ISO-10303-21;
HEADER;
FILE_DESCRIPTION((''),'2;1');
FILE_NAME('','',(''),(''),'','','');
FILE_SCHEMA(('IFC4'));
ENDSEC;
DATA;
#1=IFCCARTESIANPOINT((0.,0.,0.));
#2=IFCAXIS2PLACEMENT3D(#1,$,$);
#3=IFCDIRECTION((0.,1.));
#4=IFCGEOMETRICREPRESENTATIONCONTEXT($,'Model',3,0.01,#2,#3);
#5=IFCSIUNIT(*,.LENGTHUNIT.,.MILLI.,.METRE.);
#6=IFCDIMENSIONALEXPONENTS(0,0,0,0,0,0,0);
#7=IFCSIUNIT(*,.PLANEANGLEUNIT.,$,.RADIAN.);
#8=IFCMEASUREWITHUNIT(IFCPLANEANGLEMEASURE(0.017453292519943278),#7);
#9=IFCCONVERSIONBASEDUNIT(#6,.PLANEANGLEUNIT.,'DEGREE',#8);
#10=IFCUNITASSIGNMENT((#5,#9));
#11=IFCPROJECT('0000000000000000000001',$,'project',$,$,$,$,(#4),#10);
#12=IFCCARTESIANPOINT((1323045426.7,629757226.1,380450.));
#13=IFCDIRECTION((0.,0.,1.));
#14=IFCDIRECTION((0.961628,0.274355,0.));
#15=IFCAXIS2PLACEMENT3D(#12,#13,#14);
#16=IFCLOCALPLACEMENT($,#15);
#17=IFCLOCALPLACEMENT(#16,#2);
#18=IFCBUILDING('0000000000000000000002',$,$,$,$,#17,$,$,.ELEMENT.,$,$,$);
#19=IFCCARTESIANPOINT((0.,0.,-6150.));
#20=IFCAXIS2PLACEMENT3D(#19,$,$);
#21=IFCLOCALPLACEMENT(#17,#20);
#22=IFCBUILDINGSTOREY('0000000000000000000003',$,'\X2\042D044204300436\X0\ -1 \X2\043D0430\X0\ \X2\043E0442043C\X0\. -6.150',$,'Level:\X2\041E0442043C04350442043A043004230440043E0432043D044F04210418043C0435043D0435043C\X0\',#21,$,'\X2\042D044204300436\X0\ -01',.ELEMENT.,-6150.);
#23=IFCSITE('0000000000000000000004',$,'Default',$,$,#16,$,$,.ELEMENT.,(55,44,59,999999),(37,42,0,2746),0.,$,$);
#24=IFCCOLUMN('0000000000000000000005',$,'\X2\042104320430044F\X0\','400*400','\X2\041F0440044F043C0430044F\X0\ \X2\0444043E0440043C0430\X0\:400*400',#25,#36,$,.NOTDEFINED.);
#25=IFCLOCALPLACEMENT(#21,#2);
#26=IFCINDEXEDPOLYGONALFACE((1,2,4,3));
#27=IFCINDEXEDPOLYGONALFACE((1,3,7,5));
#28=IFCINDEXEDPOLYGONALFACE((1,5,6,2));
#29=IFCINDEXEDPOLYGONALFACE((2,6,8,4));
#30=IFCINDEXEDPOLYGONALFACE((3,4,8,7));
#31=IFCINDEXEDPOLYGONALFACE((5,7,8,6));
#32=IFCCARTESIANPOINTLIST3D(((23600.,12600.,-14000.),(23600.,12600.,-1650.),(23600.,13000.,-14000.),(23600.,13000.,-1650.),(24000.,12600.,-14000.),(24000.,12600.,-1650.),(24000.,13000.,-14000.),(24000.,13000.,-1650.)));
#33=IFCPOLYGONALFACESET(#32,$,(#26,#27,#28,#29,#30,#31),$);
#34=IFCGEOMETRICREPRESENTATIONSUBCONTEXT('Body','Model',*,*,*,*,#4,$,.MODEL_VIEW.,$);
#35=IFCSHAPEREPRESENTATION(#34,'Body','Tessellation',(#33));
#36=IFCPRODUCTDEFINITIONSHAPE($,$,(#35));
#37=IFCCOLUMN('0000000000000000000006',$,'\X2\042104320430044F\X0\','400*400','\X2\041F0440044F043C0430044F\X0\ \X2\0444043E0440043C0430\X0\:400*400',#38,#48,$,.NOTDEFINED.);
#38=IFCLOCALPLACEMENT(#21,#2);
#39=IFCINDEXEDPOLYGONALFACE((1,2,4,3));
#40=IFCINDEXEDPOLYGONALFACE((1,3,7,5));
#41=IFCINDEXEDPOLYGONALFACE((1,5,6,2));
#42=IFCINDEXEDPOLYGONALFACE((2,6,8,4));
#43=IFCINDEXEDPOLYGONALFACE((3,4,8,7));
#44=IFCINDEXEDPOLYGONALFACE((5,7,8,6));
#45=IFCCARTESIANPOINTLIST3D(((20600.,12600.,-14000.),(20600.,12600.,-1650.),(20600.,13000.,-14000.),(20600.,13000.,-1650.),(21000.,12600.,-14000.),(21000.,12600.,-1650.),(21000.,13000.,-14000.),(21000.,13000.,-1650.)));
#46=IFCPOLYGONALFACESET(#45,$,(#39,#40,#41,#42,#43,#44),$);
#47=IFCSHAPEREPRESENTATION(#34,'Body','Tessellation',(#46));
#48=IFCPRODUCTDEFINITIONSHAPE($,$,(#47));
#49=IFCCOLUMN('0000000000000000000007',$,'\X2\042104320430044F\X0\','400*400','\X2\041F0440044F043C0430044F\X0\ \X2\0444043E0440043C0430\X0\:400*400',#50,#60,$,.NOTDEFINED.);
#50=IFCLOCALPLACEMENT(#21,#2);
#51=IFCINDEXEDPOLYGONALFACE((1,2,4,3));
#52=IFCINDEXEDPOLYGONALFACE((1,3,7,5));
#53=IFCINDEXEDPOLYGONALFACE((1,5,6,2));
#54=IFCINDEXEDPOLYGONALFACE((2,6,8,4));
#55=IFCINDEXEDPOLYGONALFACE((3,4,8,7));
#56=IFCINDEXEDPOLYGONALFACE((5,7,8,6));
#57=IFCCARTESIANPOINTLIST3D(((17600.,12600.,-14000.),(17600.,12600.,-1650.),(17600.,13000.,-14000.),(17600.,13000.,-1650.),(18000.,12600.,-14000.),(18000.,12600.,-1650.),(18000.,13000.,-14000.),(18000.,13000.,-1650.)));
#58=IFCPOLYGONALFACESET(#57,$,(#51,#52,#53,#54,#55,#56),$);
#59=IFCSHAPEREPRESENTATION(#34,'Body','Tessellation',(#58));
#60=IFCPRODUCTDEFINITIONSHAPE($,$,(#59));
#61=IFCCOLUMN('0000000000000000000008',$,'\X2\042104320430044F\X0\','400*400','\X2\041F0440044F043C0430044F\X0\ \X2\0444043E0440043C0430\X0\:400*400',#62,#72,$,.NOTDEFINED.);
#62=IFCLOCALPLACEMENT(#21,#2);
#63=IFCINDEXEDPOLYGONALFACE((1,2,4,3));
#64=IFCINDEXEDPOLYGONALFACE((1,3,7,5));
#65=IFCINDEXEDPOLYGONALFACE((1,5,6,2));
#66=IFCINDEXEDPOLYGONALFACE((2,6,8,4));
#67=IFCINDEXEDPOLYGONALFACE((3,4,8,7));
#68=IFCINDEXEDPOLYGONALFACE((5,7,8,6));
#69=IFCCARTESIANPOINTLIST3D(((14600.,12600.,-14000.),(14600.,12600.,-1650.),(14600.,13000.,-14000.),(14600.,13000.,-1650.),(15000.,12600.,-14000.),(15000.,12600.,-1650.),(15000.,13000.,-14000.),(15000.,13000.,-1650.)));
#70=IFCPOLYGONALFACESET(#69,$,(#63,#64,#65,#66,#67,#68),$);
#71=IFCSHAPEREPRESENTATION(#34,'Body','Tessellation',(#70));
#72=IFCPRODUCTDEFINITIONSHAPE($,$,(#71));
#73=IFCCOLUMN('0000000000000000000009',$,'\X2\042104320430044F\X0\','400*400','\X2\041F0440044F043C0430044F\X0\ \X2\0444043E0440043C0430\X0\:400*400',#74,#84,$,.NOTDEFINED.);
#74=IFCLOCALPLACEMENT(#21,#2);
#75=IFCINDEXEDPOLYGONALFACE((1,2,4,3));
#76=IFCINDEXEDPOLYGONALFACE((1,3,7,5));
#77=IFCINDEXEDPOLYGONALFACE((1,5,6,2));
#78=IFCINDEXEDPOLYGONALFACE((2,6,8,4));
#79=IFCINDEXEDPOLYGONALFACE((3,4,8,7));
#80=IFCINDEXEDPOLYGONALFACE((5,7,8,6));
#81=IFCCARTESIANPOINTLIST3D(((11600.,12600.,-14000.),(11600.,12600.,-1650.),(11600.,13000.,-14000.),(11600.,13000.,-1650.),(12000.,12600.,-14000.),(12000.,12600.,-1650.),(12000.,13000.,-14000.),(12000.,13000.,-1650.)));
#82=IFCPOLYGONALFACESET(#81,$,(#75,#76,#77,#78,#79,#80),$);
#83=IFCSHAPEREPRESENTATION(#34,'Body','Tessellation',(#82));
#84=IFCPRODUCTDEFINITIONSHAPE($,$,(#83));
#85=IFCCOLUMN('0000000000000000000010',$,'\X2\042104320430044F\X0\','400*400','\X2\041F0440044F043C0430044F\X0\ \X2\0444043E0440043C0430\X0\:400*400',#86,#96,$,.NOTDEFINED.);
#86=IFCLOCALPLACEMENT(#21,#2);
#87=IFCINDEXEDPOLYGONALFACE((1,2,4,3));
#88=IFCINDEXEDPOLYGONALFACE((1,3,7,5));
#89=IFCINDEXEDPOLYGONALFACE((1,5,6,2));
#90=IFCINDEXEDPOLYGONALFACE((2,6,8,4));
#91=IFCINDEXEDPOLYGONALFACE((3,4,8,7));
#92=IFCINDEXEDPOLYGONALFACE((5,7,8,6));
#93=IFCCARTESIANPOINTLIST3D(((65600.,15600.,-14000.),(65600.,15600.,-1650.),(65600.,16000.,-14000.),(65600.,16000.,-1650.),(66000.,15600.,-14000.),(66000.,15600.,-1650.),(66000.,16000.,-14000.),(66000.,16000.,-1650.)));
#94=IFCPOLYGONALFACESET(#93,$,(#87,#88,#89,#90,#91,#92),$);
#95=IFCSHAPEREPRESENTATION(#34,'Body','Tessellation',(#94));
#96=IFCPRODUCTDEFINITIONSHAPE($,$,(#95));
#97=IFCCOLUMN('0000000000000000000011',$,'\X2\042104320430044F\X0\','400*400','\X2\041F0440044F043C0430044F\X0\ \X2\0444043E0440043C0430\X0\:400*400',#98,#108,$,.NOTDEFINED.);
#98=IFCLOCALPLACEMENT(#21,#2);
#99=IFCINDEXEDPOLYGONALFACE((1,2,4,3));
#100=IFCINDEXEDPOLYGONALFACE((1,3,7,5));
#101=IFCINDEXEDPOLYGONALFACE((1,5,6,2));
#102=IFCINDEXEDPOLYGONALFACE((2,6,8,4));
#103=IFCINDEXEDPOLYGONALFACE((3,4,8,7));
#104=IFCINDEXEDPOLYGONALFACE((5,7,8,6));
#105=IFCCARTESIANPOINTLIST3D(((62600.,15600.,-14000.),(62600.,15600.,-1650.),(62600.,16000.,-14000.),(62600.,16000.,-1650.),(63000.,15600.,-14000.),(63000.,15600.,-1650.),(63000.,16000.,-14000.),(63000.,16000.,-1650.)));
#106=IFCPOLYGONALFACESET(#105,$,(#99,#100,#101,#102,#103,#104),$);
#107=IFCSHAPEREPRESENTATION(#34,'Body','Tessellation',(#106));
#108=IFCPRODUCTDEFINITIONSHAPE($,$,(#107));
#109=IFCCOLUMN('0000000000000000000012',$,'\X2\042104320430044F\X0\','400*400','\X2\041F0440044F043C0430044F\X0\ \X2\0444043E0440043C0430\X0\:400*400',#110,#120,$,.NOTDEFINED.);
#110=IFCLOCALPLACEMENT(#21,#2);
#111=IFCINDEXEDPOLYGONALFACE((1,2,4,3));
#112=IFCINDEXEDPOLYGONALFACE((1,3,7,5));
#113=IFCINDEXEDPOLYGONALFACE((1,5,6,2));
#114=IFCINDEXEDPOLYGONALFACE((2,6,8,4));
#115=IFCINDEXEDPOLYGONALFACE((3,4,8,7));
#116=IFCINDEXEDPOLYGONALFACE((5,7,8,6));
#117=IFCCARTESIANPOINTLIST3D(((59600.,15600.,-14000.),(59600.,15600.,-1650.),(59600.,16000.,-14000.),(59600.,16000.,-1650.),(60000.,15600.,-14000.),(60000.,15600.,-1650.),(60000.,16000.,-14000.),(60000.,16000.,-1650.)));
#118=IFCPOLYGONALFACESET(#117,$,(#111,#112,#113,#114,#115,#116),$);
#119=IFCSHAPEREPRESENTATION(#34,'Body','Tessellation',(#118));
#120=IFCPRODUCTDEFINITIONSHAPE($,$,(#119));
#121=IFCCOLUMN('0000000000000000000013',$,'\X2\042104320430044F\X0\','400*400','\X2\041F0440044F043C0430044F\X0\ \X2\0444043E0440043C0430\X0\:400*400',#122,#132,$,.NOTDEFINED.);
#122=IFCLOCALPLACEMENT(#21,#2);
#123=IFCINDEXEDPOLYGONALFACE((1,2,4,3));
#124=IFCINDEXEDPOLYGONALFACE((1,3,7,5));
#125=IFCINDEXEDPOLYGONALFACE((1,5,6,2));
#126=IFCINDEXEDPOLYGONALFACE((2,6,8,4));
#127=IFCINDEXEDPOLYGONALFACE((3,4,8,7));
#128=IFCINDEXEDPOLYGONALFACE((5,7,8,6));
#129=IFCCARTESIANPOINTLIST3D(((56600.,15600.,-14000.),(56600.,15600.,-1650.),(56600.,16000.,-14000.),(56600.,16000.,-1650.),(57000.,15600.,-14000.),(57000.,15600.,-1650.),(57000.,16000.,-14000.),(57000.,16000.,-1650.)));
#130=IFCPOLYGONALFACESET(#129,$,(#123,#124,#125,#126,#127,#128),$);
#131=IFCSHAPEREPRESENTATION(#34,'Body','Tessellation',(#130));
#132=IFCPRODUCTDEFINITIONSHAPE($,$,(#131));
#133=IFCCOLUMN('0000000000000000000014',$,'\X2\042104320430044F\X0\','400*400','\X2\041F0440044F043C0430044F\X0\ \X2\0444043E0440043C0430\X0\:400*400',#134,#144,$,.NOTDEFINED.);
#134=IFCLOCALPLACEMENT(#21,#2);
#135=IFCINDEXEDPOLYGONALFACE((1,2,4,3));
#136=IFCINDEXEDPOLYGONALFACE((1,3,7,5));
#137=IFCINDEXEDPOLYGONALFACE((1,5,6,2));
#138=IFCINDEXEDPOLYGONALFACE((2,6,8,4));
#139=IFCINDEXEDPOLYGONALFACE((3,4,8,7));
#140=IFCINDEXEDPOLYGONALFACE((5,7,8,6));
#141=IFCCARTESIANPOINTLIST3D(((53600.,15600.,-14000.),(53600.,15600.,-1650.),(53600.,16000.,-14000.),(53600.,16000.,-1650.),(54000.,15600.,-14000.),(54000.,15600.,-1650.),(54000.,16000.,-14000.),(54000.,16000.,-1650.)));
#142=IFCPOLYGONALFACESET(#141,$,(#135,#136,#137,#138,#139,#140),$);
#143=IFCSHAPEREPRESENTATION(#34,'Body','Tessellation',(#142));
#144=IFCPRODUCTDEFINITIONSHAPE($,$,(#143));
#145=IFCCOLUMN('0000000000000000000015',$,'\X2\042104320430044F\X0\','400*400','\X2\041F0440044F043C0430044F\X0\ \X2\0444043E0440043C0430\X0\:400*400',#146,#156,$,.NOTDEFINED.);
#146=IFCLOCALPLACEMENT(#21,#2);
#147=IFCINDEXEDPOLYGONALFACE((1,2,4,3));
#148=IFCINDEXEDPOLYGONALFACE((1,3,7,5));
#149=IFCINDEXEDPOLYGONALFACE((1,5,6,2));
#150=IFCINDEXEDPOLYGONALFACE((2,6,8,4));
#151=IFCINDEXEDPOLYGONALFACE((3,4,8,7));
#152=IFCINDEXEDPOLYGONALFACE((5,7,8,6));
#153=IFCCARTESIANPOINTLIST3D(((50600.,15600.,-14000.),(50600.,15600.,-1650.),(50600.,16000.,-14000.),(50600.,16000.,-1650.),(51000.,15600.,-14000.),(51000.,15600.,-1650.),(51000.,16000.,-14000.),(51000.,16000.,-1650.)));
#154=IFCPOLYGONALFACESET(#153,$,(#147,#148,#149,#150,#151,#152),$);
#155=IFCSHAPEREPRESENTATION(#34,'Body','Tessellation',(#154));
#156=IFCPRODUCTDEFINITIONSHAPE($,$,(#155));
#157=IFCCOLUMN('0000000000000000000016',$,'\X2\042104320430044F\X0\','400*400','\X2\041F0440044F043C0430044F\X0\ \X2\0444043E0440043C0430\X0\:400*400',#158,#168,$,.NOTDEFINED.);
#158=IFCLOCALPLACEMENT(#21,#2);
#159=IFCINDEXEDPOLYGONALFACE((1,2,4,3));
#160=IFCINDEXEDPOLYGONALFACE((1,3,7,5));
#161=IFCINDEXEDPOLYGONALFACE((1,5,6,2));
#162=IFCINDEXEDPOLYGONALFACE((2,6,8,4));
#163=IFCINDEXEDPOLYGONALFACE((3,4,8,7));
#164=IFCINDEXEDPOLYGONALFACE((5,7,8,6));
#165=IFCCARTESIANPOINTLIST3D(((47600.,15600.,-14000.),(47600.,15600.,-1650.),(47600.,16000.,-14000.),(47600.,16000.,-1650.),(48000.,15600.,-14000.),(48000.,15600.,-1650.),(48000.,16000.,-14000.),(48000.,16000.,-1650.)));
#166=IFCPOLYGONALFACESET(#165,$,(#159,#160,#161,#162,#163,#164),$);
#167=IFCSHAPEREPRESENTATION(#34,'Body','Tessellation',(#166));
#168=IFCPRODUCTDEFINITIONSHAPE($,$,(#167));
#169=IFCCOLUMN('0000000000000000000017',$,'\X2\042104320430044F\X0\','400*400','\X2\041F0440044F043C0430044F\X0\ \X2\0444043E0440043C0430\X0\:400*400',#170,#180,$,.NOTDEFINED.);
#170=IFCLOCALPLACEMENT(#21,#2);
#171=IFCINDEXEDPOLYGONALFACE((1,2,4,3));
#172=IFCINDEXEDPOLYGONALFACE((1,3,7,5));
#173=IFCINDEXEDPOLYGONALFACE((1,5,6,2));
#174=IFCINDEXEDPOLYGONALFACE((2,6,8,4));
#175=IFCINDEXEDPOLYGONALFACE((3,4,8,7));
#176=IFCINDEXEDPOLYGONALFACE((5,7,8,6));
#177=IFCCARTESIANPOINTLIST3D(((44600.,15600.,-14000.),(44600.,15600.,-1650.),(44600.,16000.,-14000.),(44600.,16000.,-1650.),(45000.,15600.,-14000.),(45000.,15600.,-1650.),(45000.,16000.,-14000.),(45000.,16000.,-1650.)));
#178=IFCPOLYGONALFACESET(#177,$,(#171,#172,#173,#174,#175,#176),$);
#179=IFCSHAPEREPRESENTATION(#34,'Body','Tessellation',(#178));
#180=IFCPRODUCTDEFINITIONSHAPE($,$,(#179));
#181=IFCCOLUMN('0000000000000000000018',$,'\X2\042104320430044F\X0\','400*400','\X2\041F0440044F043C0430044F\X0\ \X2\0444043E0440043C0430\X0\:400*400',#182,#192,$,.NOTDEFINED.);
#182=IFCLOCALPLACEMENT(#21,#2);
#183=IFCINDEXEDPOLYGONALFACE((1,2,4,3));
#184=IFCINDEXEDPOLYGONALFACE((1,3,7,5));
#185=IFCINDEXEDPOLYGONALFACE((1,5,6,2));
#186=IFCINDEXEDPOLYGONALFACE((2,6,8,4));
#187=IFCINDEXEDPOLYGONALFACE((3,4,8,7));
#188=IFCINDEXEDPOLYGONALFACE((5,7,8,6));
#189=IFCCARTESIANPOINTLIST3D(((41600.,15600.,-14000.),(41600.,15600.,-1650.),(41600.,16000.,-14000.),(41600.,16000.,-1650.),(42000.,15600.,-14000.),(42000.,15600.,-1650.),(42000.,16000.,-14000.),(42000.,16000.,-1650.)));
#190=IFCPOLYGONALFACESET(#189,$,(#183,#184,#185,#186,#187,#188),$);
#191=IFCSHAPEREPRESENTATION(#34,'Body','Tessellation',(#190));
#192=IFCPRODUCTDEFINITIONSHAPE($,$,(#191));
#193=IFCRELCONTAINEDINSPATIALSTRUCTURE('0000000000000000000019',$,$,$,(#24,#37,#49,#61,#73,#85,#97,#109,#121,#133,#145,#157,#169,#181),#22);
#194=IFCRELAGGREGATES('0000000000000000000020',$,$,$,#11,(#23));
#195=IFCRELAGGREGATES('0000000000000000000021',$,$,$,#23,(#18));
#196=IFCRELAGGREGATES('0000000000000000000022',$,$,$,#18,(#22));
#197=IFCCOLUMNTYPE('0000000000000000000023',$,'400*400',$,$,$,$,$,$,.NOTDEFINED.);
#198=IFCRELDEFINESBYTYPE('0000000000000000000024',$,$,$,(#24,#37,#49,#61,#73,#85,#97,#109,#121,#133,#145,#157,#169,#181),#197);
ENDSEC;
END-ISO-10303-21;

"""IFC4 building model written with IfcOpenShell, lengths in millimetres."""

from ifc_helpers import new_model, entity, si_unit, converted_unit, direction, frame, origin, place, context, subcontext, project, spatial, indexed_curve, outline, extrude, type_object, element, save


model = new_model("IFC4")

# Units and contexts
model_context = context("Model", 3, precision=0.01, world=origin(), true_north=direction((0.0, 1.0)))
body_context = subcontext(model_context, "Body", "Model", "MODEL_VIEW")
ifc_project = project(units=[si_unit("LENGTHUNIT", "METRE", prefix="MILLI"), converted_unit("PLANEANGLEUNIT", "DEGREE", entity("IfcPlaneAngleMeasure", 0.017453292519943278), si_unit("PLANEANGLEUNIT", "RADIAN"), dimensions=[0, 0, 0, 0, 0, 0, 0])], contexts=[model_context])

# Site, building, storey
site_placement = place(None, frame((1323045426.7, 629757226.1, 380450.0), z_axis=(0.0, 0.0, 1.0), x_axis=(0.961628, 0.274355, 0.0)))
site = spatial("IfcSite", under=ifc_project, at=site_placement, Name="Default", CompositionType="ELEMENT", RefLatitude=(55, 44, 59, 999999), RefLongitude=(37, 42, 0, 2746), RefElevation=0.0)
building_placement = place(site_placement, origin())
building = spatial("IfcBuilding", under=site, at=building_placement, CompositionType="ELEMENT")
storey_placement = place(building_placement, frame((0.0, 0.0, -6150.0)))
storey = spatial("IfcBuildingStorey", under=building, at=storey_placement, Name="Этаж -1 на отм. -6.150", ObjectType="Level:ОтметкаУровняСИменем", LongName="Этаж -01", CompositionType="ELEMENT", Elevation=-6150.0)

# Columns
column_type = type_object("IfcColumnType", Name="400*400", PredefinedType="NOTDEFINED")
column_1_placement = place(storey_placement, origin())
element("IfcColumn", 1, at=column_1_placement, inside=storey, type_object=column_type, Name="Свая", Description="400*400", ObjectType="Прямая форма:400*400", PredefinedType="NOTDEFINED", context=body_context, shape_type="SweptSolid", body=[
    extrude(outline(indexed_curve([(-200.0, -200.0), (200.0, -200.0), (200.0, 200.0), (-200.0, 200.0), (-200.0, -200.0)], self_intersect=False)), frame((23800.0, 12800.0, -14000.0), z_axis=(0.0, 0.0, 1.0), x_axis=(0.0, 1.0, 0.0)), (0.0, 0.0, 1.0), 12350.0),
])
column_2_placement = place(storey_placement, origin())
element("IfcColumn", 2, at=column_2_placement, inside=storey, type_object=column_type, Name="Свая", Description="400*400", ObjectType="Прямая форма:400*400", PredefinedType="NOTDEFINED", context=body_context, shape_type="SweptSolid", body=[
    extrude(outline(indexed_curve([(-200.0, -200.0), (200.0, -200.0), (200.0, 200.0), (-200.0, 200.0), (-200.0, -200.0)], self_intersect=False)), frame((20800.0, 12800.0, -14000.0), z_axis=(0.0, 0.0, 1.0), x_axis=(0.0, 1.0, 0.0)), (0.0, 0.0, 1.0), 12350.0),
])
column_3_placement = place(storey_placement, origin())
element("IfcColumn", 3, at=column_3_placement, inside=storey, type_object=column_type, Name="Свая", Description="400*400", ObjectType="Прямая форма:400*400", PredefinedType="NOTDEFINED", context=body_context, shape_type="SweptSolid", body=[
    extrude(outline(indexed_curve([(-200.0, -200.0), (200.0, -200.0), (200.0, 200.0), (-200.0, 200.0), (-200.0, -200.0)], self_intersect=False)), frame((17800.0, 12800.0, -14000.0), z_axis=(0.0, 0.0, 1.0), x_axis=(0.0, 1.0, 0.0)), (0.0, 0.0, 1.0), 12350.0),
])
column_4_placement = place(storey_placement, origin())
element("IfcColumn", 4, at=column_4_placement, inside=storey, type_object=column_type, Name="Свая", Description="400*400", ObjectType="Прямая форма:400*400", PredefinedType="NOTDEFINED", context=body_context, shape_type="SweptSolid", body=[
    extrude(outline(indexed_curve([(-200.0, -200.0), (200.0, -200.0), (200.0, 200.0), (-200.0, 200.0), (-200.0, -200.0)], self_intersect=False)), frame((14800.0, 12800.0, -14000.0), z_axis=(0.0, 0.0, 1.0), x_axis=(0.0, 1.0, 0.0)), (0.0, 0.0, 1.0), 12350.0),
])
column_5_placement = place(storey_placement, origin())
element("IfcColumn", 5, at=column_5_placement, inside=storey, type_object=column_type, Name="Свая", Description="400*400", ObjectType="Прямая форма:400*400", PredefinedType="NOTDEFINED", context=body_context, shape_type="SweptSolid", body=[
    extrude(outline(indexed_curve([(-200.0, -200.0), (200.0, -200.0), (200.0, 200.0), (-200.0, 200.0), (-200.0, -200.0)], self_intersect=False)), frame((11800.0, 12800.0, -14000.0), z_axis=(0.0, 0.0, 1.0), x_axis=(0.0, 1.0, 0.0)), (0.0, 0.0, 1.0), 12350.0),
])
column_6_placement = place(storey_placement, origin())
element("IfcColumn", 6, at=column_6_placement, inside=storey, type_object=column_type, Name="Свая", Description="400*400", ObjectType="Прямая форма:400*400", PredefinedType="NOTDEFINED", context=body_context, shape_type="SweptSolid", body=[
    extrude(outline(indexed_curve([(-200.0, -200.0), (200.0, -200.0), (200.0, 200.0), (-200.0, 200.0), (-200.0, -200.0)], self_intersect=False)), frame((65800.0, 15800.0, -14000.0), z_axis=(0.0, 0.0, 1.0), x_axis=(0.0, 1.0, 0.0)), (0.0, 0.0, 1.0), 12350.0),
])
column_7_placement = place(storey_placement, origin())
element("IfcColumn", 7, at=column_7_placement, inside=storey, type_object=column_type, Name="Свая", Description="400*400", ObjectType="Прямая форма:400*400", PredefinedType="NOTDEFINED", context=body_context, shape_type="SweptSolid", body=[
    extrude(outline(indexed_curve([(-200.0, -200.0), (200.0, -200.0), (200.0, 200.0), (-200.0, 200.0), (-200.0, -200.0)], self_intersect=False)), frame((62800.0, 15800.0, -14000.0), z_axis=(0.0, 0.0, 1.0), x_axis=(0.0, 1.0, 0.0)), (0.0, 0.0, 1.0), 12350.0),
])
column_8_placement = place(storey_placement, origin())
element("IfcColumn", 8, at=column_8_placement, inside=storey, type_object=column_type, Name="Свая", Description="400*400", ObjectType="Прямая форма:400*400", PredefinedType="NOTDEFINED", context=body_context, shape_type="SweptSolid", body=[
    extrude(outline(indexed_curve([(-200.0, -200.0), (200.0, -200.0), (200.0, 200.0), (-200.0, 200.0), (-200.0, -200.0)], self_intersect=False)), frame((59800.0, 15800.0, -14000.0), z_axis=(0.0, 0.0, 1.0), x_axis=(0.0, 1.0, 0.0)), (0.0, 0.0, 1.0), 12350.0),
])
column_9_placement = place(storey_placement, origin())
element("IfcColumn", 9, at=column_9_placement, inside=storey, type_object=column_type, Name="Свая", Description="400*400", ObjectType="Прямая форма:400*400", PredefinedType="NOTDEFINED", context=body_context, shape_type="SweptSolid", body=[
    extrude(outline(indexed_curve([(-200.0, -200.0), (200.0, -200.0), (200.0, 200.0), (-200.0, 200.0), (-200.0, -200.0)], self_intersect=False)), frame((56800.0, 15800.0, -14000.0), z_axis=(0.0, 0.0, 1.0), x_axis=(0.0, 1.0, 0.0)), (0.0, 0.0, 1.0), 12350.0),
])
column_10_placement = place(storey_placement, origin())
element("IfcColumn", 10, at=column_10_placement, inside=storey, type_object=column_type, Name="Свая", Description="400*400", ObjectType="Прямая форма:400*400", PredefinedType="NOTDEFINED", context=body_context, shape_type="SweptSolid", body=[
    extrude(outline(indexed_curve([(-200.0, -200.0), (200.0, -200.0), (200.0, 200.0), (-200.0, 200.0), (-200.0, -200.0)], self_intersect=False)), frame((53800.0, 15800.0, -14000.0), z_axis=(0.0, 0.0, 1.0), x_axis=(0.0, 1.0, 0.0)), (0.0, 0.0, 1.0), 12350.0),
])
column_11_placement = place(storey_placement, origin())
element("IfcColumn", 11, at=column_11_placement, inside=storey, type_object=column_type, Name="Свая", Description="400*400", ObjectType="Прямая форма:400*400", PredefinedType="NOTDEFINED", context=body_context, shape_type="SweptSolid", body=[
    extrude(outline(indexed_curve([(-200.0, -200.0), (200.0, -200.0), (200.0, 200.0), (-200.0, 200.0), (-200.0, -200.0)], self_intersect=False)), frame((50800.0, 15800.0, -14000.0), z_axis=(0.0, 0.0, 1.0), x_axis=(0.0, 1.0, 0.0)), (0.0, 0.0, 1.0), 12350.0),
])
column_12_placement = place(storey_placement, origin())
element("IfcColumn", 12, at=column_12_placement, inside=storey, type_object=column_type, Name="Свая", Description="400*400", ObjectType="Прямая форма:400*400", PredefinedType="NOTDEFINED", context=body_context, shape_type="SweptSolid", body=[
    extrude(outline(indexed_curve([(-200.0, -200.0), (200.0, -200.0), (200.0, 200.0), (-200.0, 200.0), (-200.0, -200.0)], self_intersect=False)), frame((47800.0, 15800.0, -14000.0), z_axis=(0.0, 0.0, 1.0), x_axis=(0.0, 1.0, 0.0)), (0.0, 0.0, 1.0), 12350.0),
])
column_13_placement = place(storey_placement, origin())
element("IfcColumn", 13, at=column_13_placement, inside=storey, type_object=column_type, Name="Свая", Description="400*400", ObjectType="Прямая форма:400*400", PredefinedType="NOTDEFINED", context=body_context, shape_type="SweptSolid", body=[
    extrude(outline(indexed_curve([(-200.0, -200.0), (200.0, -200.0), (200.0, 200.0), (-200.0, 200.0), (-200.0, -200.0)], self_intersect=False)), frame((44800.0, 15800.0, -14000.0), z_axis=(0.0, 0.0, 1.0), x_axis=(0.0, 1.0, 0.0)), (0.0, 0.0, 1.0), 12350.0),
])
column_14_placement = place(storey_placement, origin())
element("IfcColumn", 14, at=column_14_placement, inside=storey, type_object=column_type, Name="Свая", Description="400*400", ObjectType="Прямая форма:400*400", PredefinedType="NOTDEFINED", context=body_context, shape_type="SweptSolid", body=[
    extrude(outline(indexed_curve([(-200.0, -200.0), (200.0, -200.0), (200.0, 200.0), (-200.0, 200.0), (-200.0, -200.0)], self_intersect=False)), frame((41800.0, 15800.0, -14000.0), z_axis=(0.0, 0.0, 1.0), x_axis=(0.0, 1.0, 0.0)), (0.0, 0.0, 1.0), 12350.0),
])

save(model, "model.ifc")
